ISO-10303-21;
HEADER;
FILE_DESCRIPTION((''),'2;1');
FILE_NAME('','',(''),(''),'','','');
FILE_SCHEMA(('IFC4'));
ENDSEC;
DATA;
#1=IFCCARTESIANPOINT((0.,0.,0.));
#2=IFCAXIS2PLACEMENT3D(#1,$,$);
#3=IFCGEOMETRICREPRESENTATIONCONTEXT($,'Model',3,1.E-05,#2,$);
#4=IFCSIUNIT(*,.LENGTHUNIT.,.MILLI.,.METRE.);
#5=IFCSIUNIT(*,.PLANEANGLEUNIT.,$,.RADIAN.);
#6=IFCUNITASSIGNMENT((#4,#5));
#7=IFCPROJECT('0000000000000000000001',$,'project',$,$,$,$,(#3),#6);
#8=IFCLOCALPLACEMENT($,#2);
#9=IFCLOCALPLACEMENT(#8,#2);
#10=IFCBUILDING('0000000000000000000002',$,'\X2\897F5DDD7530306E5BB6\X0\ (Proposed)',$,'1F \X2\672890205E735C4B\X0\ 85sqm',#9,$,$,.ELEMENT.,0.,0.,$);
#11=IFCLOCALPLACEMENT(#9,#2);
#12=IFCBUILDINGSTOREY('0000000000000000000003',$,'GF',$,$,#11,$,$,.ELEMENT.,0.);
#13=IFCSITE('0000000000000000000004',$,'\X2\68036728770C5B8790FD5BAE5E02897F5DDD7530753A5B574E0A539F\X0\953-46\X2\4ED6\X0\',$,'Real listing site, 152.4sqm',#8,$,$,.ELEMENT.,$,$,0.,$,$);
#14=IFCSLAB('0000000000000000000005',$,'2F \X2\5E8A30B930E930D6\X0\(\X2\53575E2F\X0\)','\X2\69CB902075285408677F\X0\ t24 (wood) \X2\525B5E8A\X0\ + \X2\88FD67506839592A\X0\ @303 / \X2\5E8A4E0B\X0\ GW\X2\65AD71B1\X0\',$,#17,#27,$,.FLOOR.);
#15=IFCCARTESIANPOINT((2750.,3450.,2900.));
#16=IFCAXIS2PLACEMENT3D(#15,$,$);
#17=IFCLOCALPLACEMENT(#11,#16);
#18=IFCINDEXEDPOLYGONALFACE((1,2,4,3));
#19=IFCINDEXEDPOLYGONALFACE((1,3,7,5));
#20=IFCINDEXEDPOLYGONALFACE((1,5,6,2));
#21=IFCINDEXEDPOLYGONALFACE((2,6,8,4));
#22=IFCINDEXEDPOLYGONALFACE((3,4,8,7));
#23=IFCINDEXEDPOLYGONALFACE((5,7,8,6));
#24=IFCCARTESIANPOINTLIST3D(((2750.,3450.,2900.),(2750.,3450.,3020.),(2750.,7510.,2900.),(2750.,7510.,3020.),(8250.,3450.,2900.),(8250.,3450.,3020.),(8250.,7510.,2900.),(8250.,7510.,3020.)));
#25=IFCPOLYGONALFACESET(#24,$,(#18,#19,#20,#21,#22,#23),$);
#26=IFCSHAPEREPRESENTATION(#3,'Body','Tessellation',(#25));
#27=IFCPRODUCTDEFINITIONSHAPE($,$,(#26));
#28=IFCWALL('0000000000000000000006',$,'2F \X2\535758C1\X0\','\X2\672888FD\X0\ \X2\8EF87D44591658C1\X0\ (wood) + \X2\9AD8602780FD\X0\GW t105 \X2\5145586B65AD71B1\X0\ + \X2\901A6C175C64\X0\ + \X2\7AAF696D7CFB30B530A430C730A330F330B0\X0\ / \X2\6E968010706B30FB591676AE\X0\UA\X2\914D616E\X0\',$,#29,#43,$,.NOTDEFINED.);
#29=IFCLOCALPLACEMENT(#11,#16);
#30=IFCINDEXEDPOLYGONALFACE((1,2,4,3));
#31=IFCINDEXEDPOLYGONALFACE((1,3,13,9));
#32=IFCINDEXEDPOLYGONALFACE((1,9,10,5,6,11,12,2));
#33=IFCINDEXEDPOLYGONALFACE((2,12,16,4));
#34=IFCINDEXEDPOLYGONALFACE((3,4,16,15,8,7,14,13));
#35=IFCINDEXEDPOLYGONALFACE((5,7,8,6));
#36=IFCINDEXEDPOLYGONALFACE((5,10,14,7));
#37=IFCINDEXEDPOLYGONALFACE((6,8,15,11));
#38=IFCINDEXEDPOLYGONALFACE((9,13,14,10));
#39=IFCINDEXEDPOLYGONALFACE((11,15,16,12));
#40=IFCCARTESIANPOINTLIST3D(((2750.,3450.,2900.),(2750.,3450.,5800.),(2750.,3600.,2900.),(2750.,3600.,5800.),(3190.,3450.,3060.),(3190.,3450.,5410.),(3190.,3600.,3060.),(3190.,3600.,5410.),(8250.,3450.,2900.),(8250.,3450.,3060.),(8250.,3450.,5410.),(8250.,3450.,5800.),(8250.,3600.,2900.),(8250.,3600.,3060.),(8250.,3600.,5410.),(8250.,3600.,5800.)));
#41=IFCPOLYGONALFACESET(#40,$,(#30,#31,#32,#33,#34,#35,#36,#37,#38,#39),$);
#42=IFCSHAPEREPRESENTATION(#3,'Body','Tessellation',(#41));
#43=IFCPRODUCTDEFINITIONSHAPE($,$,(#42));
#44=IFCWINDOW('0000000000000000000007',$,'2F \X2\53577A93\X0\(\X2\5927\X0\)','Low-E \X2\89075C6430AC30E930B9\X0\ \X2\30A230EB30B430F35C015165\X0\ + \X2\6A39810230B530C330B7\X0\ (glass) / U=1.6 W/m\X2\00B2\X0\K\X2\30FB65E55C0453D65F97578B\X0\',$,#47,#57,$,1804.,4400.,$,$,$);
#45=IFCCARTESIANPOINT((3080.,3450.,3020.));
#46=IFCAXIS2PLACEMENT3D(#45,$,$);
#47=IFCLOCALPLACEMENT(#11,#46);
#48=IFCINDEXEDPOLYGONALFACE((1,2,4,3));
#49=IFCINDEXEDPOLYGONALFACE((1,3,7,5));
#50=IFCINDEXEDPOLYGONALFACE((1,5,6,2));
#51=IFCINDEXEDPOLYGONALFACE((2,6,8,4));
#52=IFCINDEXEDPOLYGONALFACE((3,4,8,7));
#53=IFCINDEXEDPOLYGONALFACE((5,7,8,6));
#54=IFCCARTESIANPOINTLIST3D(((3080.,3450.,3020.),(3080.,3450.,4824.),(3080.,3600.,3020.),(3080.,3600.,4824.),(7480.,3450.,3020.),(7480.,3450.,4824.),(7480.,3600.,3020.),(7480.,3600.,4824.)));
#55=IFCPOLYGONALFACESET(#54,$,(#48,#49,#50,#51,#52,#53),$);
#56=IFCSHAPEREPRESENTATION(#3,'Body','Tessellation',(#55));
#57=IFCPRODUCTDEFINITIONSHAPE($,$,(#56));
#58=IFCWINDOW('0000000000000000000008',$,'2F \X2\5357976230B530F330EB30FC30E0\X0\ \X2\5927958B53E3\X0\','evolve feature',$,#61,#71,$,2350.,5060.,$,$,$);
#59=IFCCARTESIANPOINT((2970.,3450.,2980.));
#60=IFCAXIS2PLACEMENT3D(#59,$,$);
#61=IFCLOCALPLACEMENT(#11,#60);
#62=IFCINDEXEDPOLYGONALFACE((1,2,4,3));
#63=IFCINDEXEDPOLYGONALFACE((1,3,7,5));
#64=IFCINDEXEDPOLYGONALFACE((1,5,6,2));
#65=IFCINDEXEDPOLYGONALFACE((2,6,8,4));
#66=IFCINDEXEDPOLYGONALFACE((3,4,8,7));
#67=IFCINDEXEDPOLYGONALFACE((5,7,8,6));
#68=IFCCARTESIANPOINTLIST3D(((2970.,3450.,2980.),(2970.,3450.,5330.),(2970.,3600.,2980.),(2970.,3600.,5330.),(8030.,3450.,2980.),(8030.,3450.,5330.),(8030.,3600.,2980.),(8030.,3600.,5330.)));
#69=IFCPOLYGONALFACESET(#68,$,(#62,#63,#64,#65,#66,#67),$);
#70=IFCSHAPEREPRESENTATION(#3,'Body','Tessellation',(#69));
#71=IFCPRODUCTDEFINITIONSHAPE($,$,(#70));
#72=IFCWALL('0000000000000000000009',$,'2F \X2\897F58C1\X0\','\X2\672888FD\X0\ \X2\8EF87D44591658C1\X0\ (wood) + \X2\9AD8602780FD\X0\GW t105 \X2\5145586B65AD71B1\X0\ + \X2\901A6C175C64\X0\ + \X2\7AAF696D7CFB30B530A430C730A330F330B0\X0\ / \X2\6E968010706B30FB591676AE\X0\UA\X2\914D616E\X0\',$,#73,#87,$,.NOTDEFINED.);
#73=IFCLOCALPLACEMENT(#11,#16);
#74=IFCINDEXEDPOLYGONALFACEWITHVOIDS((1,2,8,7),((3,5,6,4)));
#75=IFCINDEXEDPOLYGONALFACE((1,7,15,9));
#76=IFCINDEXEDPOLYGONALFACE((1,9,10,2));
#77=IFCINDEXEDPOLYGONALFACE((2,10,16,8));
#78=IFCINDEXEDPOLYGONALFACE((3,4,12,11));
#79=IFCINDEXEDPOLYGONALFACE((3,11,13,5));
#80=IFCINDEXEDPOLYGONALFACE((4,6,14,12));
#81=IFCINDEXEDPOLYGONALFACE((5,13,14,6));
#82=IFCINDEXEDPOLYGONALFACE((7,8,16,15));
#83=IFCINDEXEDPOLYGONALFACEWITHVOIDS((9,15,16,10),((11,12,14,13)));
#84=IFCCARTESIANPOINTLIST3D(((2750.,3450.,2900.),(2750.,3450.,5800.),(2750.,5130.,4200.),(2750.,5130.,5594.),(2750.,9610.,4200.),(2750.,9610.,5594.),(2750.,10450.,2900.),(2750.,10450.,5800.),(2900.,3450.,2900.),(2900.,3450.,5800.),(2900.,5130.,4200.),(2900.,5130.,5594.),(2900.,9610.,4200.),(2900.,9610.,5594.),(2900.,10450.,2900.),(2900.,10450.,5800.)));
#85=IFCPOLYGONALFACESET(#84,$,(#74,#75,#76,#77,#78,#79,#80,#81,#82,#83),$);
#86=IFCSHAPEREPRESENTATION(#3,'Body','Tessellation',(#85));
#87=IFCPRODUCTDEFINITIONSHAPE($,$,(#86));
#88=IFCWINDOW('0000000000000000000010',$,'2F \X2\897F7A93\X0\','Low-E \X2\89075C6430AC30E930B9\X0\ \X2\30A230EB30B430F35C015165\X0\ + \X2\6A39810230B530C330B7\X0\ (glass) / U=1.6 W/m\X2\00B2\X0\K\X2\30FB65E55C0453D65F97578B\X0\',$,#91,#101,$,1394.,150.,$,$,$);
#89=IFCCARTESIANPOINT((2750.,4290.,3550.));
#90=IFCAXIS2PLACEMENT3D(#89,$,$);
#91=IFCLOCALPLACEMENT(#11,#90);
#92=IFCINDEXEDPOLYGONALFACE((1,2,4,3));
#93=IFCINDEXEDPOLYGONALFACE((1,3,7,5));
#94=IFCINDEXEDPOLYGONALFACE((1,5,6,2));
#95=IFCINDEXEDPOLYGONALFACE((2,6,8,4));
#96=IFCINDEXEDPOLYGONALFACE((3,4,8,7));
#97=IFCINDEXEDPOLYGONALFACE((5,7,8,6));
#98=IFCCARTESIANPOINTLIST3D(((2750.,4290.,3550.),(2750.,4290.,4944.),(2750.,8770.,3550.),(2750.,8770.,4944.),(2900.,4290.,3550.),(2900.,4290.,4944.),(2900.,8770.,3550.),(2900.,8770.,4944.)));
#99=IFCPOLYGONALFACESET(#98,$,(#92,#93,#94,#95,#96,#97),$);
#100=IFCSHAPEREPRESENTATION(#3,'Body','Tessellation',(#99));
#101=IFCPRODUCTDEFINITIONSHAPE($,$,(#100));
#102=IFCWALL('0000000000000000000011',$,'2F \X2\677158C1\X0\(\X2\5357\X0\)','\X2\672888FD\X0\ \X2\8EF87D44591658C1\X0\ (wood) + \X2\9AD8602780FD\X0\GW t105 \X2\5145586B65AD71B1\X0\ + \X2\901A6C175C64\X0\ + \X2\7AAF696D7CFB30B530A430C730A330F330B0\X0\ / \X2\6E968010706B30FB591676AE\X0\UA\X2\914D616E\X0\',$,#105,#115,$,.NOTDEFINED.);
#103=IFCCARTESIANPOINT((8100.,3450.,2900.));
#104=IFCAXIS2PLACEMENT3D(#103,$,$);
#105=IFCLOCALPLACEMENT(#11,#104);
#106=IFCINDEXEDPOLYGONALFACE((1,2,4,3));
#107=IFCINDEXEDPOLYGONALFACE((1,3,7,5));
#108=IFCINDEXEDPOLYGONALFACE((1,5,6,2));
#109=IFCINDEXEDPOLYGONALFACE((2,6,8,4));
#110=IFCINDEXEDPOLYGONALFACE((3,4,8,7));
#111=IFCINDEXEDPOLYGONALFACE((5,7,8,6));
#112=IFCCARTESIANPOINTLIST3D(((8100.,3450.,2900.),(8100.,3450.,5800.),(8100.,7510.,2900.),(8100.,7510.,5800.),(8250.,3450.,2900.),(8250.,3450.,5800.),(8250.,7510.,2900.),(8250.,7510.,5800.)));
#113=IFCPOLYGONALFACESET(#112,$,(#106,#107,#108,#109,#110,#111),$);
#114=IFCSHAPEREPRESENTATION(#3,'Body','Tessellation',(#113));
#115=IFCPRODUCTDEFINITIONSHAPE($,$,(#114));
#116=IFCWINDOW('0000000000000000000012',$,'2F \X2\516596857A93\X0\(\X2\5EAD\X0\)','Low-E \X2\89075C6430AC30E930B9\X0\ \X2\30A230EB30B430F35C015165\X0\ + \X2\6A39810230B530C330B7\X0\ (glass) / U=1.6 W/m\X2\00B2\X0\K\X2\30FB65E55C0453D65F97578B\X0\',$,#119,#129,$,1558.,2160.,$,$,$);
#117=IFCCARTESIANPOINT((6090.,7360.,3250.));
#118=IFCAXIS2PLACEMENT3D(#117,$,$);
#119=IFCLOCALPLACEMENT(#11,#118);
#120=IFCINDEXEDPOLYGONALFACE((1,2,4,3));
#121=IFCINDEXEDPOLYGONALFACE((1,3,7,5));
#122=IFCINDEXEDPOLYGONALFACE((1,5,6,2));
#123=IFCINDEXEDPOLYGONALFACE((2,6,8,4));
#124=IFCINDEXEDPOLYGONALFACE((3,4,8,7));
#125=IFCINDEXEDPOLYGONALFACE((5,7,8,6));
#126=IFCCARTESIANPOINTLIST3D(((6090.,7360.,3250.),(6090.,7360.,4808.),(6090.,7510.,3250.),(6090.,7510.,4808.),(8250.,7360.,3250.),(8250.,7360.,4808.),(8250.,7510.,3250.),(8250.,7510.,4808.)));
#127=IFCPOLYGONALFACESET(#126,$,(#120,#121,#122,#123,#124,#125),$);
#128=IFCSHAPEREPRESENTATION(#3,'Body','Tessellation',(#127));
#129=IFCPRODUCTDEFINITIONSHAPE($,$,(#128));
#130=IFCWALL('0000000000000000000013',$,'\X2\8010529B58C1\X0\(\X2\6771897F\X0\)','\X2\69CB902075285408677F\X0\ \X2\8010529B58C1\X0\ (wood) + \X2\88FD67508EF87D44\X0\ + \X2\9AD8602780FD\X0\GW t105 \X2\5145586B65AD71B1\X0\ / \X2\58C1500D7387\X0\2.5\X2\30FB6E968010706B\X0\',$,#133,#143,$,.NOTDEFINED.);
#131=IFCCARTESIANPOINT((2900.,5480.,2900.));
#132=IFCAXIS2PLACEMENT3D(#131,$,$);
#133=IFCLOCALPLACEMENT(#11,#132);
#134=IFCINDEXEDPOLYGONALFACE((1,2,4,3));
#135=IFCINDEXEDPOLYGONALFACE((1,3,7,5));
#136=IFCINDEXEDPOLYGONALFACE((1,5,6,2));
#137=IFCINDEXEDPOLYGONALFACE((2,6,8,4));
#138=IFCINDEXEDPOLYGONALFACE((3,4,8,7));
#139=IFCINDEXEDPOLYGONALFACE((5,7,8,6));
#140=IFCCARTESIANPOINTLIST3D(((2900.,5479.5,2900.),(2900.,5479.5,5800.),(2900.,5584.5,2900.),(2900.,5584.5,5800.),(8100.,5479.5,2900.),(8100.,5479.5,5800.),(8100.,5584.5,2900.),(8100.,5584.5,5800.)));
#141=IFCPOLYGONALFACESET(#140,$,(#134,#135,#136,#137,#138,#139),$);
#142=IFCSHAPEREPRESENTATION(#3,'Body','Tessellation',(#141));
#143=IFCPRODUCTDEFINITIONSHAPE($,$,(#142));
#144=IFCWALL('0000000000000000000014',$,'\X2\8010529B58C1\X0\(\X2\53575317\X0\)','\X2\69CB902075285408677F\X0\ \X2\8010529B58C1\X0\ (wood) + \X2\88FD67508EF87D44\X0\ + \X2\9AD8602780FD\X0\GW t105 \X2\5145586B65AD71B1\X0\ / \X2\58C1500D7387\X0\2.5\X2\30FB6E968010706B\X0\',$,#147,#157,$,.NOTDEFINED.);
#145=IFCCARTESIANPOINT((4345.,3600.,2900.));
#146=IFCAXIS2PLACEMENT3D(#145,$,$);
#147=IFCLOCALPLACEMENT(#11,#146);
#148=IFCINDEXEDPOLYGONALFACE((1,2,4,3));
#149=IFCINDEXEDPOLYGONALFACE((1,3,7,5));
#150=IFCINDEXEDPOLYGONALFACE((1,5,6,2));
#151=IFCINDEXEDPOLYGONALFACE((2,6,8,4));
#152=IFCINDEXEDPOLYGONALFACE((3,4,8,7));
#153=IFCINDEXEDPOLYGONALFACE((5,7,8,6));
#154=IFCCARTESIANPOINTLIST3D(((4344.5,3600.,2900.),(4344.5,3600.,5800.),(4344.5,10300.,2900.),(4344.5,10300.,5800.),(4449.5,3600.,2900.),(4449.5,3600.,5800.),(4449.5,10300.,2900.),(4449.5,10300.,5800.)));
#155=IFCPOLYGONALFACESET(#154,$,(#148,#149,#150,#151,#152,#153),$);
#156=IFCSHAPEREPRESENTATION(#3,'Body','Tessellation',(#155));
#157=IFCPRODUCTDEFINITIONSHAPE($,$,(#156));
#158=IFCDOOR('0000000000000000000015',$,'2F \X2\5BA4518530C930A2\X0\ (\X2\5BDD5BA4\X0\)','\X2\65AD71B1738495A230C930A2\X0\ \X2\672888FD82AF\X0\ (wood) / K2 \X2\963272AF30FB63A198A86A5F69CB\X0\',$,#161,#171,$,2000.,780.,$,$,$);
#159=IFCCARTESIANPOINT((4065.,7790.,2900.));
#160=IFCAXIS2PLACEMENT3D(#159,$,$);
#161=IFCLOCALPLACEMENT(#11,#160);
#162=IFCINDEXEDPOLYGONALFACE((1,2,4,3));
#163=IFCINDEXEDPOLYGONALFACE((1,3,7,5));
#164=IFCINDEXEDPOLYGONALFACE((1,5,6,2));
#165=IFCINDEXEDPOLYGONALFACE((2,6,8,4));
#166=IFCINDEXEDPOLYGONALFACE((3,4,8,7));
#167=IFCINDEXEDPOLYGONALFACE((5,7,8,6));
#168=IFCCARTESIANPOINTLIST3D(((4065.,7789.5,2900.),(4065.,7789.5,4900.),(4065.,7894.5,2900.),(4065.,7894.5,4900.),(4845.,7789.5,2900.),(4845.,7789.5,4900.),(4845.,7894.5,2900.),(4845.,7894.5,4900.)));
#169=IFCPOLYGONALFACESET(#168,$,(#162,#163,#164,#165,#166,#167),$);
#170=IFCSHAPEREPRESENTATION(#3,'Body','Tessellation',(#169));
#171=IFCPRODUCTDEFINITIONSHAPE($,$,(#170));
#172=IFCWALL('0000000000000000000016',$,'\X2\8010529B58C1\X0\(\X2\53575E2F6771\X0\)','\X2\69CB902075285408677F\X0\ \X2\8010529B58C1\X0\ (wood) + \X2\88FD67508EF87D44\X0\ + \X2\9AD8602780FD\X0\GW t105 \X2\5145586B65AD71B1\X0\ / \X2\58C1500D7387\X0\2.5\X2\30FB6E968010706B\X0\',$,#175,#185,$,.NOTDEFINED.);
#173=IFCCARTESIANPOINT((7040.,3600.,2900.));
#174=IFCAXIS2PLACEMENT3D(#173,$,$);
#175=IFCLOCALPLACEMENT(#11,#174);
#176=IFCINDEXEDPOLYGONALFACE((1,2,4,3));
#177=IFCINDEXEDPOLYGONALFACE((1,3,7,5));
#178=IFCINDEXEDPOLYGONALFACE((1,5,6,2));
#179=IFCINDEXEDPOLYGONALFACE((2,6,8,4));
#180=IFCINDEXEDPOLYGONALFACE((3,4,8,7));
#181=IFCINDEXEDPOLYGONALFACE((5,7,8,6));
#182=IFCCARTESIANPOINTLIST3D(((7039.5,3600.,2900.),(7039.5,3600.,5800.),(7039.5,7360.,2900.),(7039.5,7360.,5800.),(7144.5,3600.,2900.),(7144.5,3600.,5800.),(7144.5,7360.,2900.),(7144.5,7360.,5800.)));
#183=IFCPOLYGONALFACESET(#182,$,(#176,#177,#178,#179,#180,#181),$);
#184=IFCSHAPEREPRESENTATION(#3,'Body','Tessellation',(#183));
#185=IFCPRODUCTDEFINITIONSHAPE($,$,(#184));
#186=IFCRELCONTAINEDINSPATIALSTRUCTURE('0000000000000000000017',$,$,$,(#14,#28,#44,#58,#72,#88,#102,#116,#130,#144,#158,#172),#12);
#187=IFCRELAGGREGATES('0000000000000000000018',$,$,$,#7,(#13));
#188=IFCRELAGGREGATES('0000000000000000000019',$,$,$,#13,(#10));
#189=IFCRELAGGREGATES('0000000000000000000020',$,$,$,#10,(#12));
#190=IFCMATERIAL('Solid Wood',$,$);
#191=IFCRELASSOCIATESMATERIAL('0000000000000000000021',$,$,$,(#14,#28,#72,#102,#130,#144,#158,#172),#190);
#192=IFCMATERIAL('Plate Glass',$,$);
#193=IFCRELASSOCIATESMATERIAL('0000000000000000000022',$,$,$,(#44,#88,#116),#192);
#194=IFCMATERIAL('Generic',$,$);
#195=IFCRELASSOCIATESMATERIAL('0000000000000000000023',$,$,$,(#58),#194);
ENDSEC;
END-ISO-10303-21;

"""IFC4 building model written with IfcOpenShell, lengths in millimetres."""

from ifc_helpers import new_model, si_unit, frame, frame_2d, origin, place, context, project, spatial, rectangle, extrude, material, element, fill, save


model = new_model("IFC4")

# Units and contexts
model_context = context("Model", 3, precision=1e-05, world=origin())
ifc_project = project(units=[si_unit("LENGTHUNIT", "METRE", prefix="MILLI"), si_unit("PLANEANGLEUNIT", "RADIAN")], contexts=[model_context])

# Site, building, storey
site_placement = place(None, origin())
site = spatial("IfcSite", under=ifc_project, at=site_placement, Name="栃木県宇都宮市西川田町字上原953-46他", ObjectType="Real listing site, 152.4sqm", CompositionType="ELEMENT", RefElevation=0.0)
building_placement = place(site_placement, origin())
building = spatial("IfcBuilding", under=site, at=building_placement, Name="西川田の家 (Proposed)", ObjectType="1F 木造平屋 85sqm", CompositionType="ELEMENT", ElevationOfRefHeight=0.0, ElevationOfTerrain=0.0)
storey_placement = place(building_placement, origin())
storey = spatial("IfcBuildingStorey", under=building, at=storey_placement, Name="GF", CompositionType="ELEMENT", Elevation=0.0)

# Slab
ifc_material_1 = material(Name="Solid Wood")
slab_placement = place(storey_placement, frame((2750.0, 3450.0, 2900.0)))
element("IfcSlab", 1, at=slab_placement, inside=storey, material=ifc_material_1, Name="2F 床スラブ(南帯)", Description="構造用合板 t24 (wood) 剛床 + 製材根太 @303 / 床下 GW断熱", PredefinedType="FLOOR", context=model_context, shape_type="SweptSolid", body=[
    extrude(rectangle(XDim=5500.0, YDim=4060.0, at=frame_2d((2750.0, 2030.0))), frame((2750.0, 3450.0, 2900.0)), (0.0, 0.0, 1.0), 120.0),
])

# Wall, openings, windows
wall_1_placement = place(storey_placement, frame((2750.0, 3450.0, 2900.0)))
wall_1 = element("IfcWall", 2, at=wall_1_placement, inside=storey, material=ifc_material_1, Name="2F 南壁", Description="木製 軸組外壁 (wood) + 高性能GW t105 充填断熱 + 通気層 + 窯業系サイディング / 準耐火・外皮UA配慮", PredefinedType="NOTDEFINED", context=model_context, shape_type="SweptSolid", body=[
    extrude(rectangle(XDim=5500.0, YDim=150.0, at=frame_2d((2750.0, 75.0))), frame((2750.0, 3450.0, 2900.0)), (0.0, 0.0, 1.0), 2900.0),
])
opening_1_placement = place(storey_placement, frame((3080.0, 3450.0, 3020.0)))
opening_1 = element("IfcOpeningElement", 3, at=opening_1_placement, cuts=wall_1, PredefinedType="NOTDEFINED", context=model_context, shape_type="SweptSolid", body=[
    extrude(rectangle(XDim=4400.0, YDim=150.0, at=frame_2d((2200.0, 75.0))), frame((3080.0, 3450.0, 3020.0)), (0.0, 0.0, 1.0), 1804.0),
])
opening_2_placement = place(storey_placement, frame((2970.0, 3450.0, 2980.0)))
opening_2 = element("IfcOpeningElement", 4, at=opening_2_placement, cuts=wall_1, PredefinedType="NOTDEFINED", context=model_context, shape_type="SweptSolid", body=[
    extrude(rectangle(XDim=5060.0, YDim=150.0, at=frame_2d((2530.0, 75.0))), frame((2970.0, 3450.0, 2980.0)), (0.0, 0.0, 1.0), 2350.0),
])
ifc_material_2 = material(Name="Plate Glass")
window_1_placement = place(storey_placement, frame((3080.0, 3450.0, 3020.0)))
window_1 = element("IfcWindow", 5, at=window_1_placement, inside=storey, material=ifc_material_2, Name="2F 南窓(大)", Description="Low-E 複層ガラス アルゴン封入 + 樹脂サッシ (glass) / U=1.6 W/m²K・日射取得型", OverallHeight=1804.0, OverallWidth=4400.0, context=model_context, shape_type="SweptSolid", body=[
    extrude(rectangle(XDim=4400.0, YDim=150.0, at=frame_2d((2200.0, 75.0))), frame((3080.0, 3450.0, 3020.0)), (0.0, 0.0, 1.0), 1804.0),
])
fill(opening_1, window_1)
ifc_material_3 = material(Name="Generic")
window_2_placement = place(storey_placement, frame((2970.0, 3450.0, 2980.0)))
window_2 = element("IfcWindow", 6, at=window_2_placement, inside=storey, material=ifc_material_3, Name="2F 南面サンルーム 大開口", Description="evolve feature", OverallHeight=2350.0, OverallWidth=5060.0, context=model_context, shape_type="SweptSolid", body=[
    extrude(rectangle(XDim=5060.0, YDim=150.0, at=frame_2d((2530.0, 75.0))), frame((2970.0, 3450.0, 2980.0)), (0.0, 0.0, 1.0), 2350.0),
])
fill(opening_2, window_2)

# Walls, openings, windows
wall_2_placement = place(storey_placement, frame((2750.0, 3450.0, 2900.0)))
wall_2 = element("IfcWall", 7, at=wall_2_placement, inside=storey, material=ifc_material_1, Name="2F 西壁", Description="木製 軸組外壁 (wood) + 高性能GW t105 充填断熱 + 通気層 + 窯業系サイディング / 準耐火・外皮UA配慮", PredefinedType="NOTDEFINED", context=model_context, shape_type="SweptSolid", body=[
    extrude(rectangle(XDim=150.0, YDim=7000.0, at=frame_2d((75.0, 3500.0))), frame((2750.0, 3450.0, 2900.0)), (0.0, 0.0, 1.0), 2900.0),
])
opening_3_placement = place(storey_placement, frame((2750.0, 4290.0, 3550.0)))
opening_3 = element("IfcOpeningElement", 8, at=opening_3_placement, cuts=wall_2, PredefinedType="NOTDEFINED", context=model_context, shape_type="SweptSolid", body=[
    extrude(rectangle(XDim=150.0, YDim=4480.0, at=frame_2d((75.0, 2240.0))), frame((2750.0, 4290.0, 3550.0)), (0.0, 0.0, 1.0), 1394.0),
])
window_3_placement = place(storey_placement, frame((2750.0, 4290.0, 3550.0)))
window_3 = element("IfcWindow", 9, at=window_3_placement, inside=storey, material=ifc_material_2, Name="2F 西窓", Description="Low-E 複層ガラス アルゴン封入 + 樹脂サッシ (glass) / U=1.6 W/m²K・日射取得型", OverallHeight=1394.0, OverallWidth=150.0, context=model_context, shape_type="SweptSolid", body=[
    extrude(rectangle(XDim=150.0, YDim=4480.0, at=frame_2d((75.0, 2240.0))), frame((2750.0, 4290.0, 3550.0)), (0.0, 0.0, 1.0), 1394.0),
])
fill(opening_3, window_3)
wall_3_placement = place(storey_placement, frame((8100.0, 3450.0, 2900.0)))
wall_3 = element("IfcWall", 10, at=wall_3_placement, inside=storey, material=ifc_material_1, Name="2F 東壁(南)", Description="木製 軸組外壁 (wood) + 高性能GW t105 充填断熱 + 通気層 + 窯業系サイディング / 準耐火・外皮UA配慮", PredefinedType="NOTDEFINED", context=model_context, shape_type="SweptSolid", body=[
    extrude(rectangle(XDim=150.0, YDim=4060.0, at=frame_2d((75.0, 2030.0))), frame((8100.0, 3450.0, 2900.0)), (0.0, 0.0, 1.0), 2900.0),
])
opening_4_placement = place(storey_placement, frame((6090.0, 7360.0, 3250.0)))
opening_4 = element("IfcOpeningElement", 11, at=opening_4_placement, cuts=wall_3, PredefinedType="NOTDEFINED", context=model_context, shape_type="SweptSolid", body=[
    extrude(rectangle(XDim=2160.0, YDim=150.0, at=frame_2d((1080.0, 75.0))), frame((6090.0, 7360.0, 3250.0)), (0.0, 0.0, 1.0), 1558.0),
])
window_4_placement = place(storey_placement, frame((6090.0, 7360.0, 3250.0)))
window_4 = element("IfcWindow", 12, at=window_4_placement, inside=storey, material=ifc_material_2, Name="2F 入隅窓(庭)", Description="Low-E 複層ガラス アルゴン封入 + 樹脂サッシ (glass) / U=1.6 W/m²K・日射取得型", OverallHeight=1558.0, OverallWidth=2160.0, context=model_context, shape_type="SweptSolid", body=[
    extrude(rectangle(XDim=2160.0, YDim=150.0, at=frame_2d((1080.0, 75.0))), frame((6090.0, 7360.0, 3250.0)), (0.0, 0.0, 1.0), 1558.0),
])
fill(opening_4, window_4)

# Wall
wall_4_placement = place(storey_placement, frame((2900.0, 5480.0, 2900.0)))
element("IfcWall", 13, at=wall_4_placement, inside=storey, material=ifc_material_1, Name="耐力壁(東西)", Description="構造用合板 耐力壁 (wood) + 製材軸組 + 高性能GW t105 充填断熱 / 壁倍率2.5・準耐火", PredefinedType="NOTDEFINED", context=model_context, shape_type="SweptSolid", body=[
    extrude(rectangle(XDim=5200.0, YDim=105.0, at=frame_2d((2600.0, 52.0))), frame((2900.0, 5480.0, 2900.0)), (0.0, 0.0, 1.0), 2900.0),
])

# Wall, opening, door
wall_5_placement = place(storey_placement, frame((4345.0, 3600.0, 2900.0)))
wall_5 = element("IfcWall", 14, at=wall_5_placement, inside=storey, material=ifc_material_1, Name="耐力壁(南北)", Description="構造用合板 耐力壁 (wood) + 製材軸組 + 高性能GW t105 充填断熱 / 壁倍率2.5・準耐火", PredefinedType="NOTDEFINED", context=model_context, shape_type="SweptSolid", body=[
    extrude(rectangle(XDim=105.0, YDim=6700.0, at=frame_2d((52.0, 3350.0))), frame((4345.0, 3600.0, 2900.0)), (0.0, 0.0, 1.0), 2900.0),
])
opening_5_placement = place(storey_placement, frame((4065.0, 7790.0, 2900.0)))
opening_5 = element("IfcOpeningElement", 15, at=opening_5_placement, cuts=wall_5, PredefinedType="NOTDEFINED", context=model_context, shape_type="SweptSolid", body=[
    extrude(rectangle(XDim=780.0, YDim=105.0, at=frame_2d((390.0, 52.0))), frame((4065.0, 7790.0, 2900.0)), (0.0, 0.0, 1.0), 2000.0),
])
door_placement = place(storey_placement, frame((4065.0, 7790.0, 2900.0)))
door = element("IfcDoor", 16, at=door_placement, inside=storey, material=ifc_material_1, Name="2F 室内ドア (寝室)", Description="断熱玄関ドア 木製芯 (wood) / K2 防犯・採風機構", OverallHeight=2000.0, OverallWidth=780.0, context=model_context, shape_type="SweptSolid", body=[
    extrude(rectangle(XDim=780.0, YDim=105.0, at=frame_2d((390.0, 52.0))), frame((4065.0, 7790.0, 2900.0)), (0.0, 0.0, 1.0), 2000.0),
])
fill(opening_5, door)

# Wall
wall_6_placement = place(storey_placement, frame((7040.0, 3600.0, 2900.0)))
element("IfcWall", 17, at=wall_6_placement, inside=storey, material=ifc_material_1, Name="耐力壁(南帯東)", Description="構造用合板 耐力壁 (wood) + 製材軸組 + 高性能GW t105 充填断熱 / 壁倍率2.5・準耐火", PredefinedType="NOTDEFINED", context=model_context, shape_type="SweptSolid", body=[
    extrude(rectangle(XDim=105.0, YDim=3760.0, at=frame_2d((52.0, 1880.0))), frame((7040.0, 3600.0, 2900.0)), (0.0, 0.0, 1.0), 2900.0),
])

save(model, "model.ifc")
